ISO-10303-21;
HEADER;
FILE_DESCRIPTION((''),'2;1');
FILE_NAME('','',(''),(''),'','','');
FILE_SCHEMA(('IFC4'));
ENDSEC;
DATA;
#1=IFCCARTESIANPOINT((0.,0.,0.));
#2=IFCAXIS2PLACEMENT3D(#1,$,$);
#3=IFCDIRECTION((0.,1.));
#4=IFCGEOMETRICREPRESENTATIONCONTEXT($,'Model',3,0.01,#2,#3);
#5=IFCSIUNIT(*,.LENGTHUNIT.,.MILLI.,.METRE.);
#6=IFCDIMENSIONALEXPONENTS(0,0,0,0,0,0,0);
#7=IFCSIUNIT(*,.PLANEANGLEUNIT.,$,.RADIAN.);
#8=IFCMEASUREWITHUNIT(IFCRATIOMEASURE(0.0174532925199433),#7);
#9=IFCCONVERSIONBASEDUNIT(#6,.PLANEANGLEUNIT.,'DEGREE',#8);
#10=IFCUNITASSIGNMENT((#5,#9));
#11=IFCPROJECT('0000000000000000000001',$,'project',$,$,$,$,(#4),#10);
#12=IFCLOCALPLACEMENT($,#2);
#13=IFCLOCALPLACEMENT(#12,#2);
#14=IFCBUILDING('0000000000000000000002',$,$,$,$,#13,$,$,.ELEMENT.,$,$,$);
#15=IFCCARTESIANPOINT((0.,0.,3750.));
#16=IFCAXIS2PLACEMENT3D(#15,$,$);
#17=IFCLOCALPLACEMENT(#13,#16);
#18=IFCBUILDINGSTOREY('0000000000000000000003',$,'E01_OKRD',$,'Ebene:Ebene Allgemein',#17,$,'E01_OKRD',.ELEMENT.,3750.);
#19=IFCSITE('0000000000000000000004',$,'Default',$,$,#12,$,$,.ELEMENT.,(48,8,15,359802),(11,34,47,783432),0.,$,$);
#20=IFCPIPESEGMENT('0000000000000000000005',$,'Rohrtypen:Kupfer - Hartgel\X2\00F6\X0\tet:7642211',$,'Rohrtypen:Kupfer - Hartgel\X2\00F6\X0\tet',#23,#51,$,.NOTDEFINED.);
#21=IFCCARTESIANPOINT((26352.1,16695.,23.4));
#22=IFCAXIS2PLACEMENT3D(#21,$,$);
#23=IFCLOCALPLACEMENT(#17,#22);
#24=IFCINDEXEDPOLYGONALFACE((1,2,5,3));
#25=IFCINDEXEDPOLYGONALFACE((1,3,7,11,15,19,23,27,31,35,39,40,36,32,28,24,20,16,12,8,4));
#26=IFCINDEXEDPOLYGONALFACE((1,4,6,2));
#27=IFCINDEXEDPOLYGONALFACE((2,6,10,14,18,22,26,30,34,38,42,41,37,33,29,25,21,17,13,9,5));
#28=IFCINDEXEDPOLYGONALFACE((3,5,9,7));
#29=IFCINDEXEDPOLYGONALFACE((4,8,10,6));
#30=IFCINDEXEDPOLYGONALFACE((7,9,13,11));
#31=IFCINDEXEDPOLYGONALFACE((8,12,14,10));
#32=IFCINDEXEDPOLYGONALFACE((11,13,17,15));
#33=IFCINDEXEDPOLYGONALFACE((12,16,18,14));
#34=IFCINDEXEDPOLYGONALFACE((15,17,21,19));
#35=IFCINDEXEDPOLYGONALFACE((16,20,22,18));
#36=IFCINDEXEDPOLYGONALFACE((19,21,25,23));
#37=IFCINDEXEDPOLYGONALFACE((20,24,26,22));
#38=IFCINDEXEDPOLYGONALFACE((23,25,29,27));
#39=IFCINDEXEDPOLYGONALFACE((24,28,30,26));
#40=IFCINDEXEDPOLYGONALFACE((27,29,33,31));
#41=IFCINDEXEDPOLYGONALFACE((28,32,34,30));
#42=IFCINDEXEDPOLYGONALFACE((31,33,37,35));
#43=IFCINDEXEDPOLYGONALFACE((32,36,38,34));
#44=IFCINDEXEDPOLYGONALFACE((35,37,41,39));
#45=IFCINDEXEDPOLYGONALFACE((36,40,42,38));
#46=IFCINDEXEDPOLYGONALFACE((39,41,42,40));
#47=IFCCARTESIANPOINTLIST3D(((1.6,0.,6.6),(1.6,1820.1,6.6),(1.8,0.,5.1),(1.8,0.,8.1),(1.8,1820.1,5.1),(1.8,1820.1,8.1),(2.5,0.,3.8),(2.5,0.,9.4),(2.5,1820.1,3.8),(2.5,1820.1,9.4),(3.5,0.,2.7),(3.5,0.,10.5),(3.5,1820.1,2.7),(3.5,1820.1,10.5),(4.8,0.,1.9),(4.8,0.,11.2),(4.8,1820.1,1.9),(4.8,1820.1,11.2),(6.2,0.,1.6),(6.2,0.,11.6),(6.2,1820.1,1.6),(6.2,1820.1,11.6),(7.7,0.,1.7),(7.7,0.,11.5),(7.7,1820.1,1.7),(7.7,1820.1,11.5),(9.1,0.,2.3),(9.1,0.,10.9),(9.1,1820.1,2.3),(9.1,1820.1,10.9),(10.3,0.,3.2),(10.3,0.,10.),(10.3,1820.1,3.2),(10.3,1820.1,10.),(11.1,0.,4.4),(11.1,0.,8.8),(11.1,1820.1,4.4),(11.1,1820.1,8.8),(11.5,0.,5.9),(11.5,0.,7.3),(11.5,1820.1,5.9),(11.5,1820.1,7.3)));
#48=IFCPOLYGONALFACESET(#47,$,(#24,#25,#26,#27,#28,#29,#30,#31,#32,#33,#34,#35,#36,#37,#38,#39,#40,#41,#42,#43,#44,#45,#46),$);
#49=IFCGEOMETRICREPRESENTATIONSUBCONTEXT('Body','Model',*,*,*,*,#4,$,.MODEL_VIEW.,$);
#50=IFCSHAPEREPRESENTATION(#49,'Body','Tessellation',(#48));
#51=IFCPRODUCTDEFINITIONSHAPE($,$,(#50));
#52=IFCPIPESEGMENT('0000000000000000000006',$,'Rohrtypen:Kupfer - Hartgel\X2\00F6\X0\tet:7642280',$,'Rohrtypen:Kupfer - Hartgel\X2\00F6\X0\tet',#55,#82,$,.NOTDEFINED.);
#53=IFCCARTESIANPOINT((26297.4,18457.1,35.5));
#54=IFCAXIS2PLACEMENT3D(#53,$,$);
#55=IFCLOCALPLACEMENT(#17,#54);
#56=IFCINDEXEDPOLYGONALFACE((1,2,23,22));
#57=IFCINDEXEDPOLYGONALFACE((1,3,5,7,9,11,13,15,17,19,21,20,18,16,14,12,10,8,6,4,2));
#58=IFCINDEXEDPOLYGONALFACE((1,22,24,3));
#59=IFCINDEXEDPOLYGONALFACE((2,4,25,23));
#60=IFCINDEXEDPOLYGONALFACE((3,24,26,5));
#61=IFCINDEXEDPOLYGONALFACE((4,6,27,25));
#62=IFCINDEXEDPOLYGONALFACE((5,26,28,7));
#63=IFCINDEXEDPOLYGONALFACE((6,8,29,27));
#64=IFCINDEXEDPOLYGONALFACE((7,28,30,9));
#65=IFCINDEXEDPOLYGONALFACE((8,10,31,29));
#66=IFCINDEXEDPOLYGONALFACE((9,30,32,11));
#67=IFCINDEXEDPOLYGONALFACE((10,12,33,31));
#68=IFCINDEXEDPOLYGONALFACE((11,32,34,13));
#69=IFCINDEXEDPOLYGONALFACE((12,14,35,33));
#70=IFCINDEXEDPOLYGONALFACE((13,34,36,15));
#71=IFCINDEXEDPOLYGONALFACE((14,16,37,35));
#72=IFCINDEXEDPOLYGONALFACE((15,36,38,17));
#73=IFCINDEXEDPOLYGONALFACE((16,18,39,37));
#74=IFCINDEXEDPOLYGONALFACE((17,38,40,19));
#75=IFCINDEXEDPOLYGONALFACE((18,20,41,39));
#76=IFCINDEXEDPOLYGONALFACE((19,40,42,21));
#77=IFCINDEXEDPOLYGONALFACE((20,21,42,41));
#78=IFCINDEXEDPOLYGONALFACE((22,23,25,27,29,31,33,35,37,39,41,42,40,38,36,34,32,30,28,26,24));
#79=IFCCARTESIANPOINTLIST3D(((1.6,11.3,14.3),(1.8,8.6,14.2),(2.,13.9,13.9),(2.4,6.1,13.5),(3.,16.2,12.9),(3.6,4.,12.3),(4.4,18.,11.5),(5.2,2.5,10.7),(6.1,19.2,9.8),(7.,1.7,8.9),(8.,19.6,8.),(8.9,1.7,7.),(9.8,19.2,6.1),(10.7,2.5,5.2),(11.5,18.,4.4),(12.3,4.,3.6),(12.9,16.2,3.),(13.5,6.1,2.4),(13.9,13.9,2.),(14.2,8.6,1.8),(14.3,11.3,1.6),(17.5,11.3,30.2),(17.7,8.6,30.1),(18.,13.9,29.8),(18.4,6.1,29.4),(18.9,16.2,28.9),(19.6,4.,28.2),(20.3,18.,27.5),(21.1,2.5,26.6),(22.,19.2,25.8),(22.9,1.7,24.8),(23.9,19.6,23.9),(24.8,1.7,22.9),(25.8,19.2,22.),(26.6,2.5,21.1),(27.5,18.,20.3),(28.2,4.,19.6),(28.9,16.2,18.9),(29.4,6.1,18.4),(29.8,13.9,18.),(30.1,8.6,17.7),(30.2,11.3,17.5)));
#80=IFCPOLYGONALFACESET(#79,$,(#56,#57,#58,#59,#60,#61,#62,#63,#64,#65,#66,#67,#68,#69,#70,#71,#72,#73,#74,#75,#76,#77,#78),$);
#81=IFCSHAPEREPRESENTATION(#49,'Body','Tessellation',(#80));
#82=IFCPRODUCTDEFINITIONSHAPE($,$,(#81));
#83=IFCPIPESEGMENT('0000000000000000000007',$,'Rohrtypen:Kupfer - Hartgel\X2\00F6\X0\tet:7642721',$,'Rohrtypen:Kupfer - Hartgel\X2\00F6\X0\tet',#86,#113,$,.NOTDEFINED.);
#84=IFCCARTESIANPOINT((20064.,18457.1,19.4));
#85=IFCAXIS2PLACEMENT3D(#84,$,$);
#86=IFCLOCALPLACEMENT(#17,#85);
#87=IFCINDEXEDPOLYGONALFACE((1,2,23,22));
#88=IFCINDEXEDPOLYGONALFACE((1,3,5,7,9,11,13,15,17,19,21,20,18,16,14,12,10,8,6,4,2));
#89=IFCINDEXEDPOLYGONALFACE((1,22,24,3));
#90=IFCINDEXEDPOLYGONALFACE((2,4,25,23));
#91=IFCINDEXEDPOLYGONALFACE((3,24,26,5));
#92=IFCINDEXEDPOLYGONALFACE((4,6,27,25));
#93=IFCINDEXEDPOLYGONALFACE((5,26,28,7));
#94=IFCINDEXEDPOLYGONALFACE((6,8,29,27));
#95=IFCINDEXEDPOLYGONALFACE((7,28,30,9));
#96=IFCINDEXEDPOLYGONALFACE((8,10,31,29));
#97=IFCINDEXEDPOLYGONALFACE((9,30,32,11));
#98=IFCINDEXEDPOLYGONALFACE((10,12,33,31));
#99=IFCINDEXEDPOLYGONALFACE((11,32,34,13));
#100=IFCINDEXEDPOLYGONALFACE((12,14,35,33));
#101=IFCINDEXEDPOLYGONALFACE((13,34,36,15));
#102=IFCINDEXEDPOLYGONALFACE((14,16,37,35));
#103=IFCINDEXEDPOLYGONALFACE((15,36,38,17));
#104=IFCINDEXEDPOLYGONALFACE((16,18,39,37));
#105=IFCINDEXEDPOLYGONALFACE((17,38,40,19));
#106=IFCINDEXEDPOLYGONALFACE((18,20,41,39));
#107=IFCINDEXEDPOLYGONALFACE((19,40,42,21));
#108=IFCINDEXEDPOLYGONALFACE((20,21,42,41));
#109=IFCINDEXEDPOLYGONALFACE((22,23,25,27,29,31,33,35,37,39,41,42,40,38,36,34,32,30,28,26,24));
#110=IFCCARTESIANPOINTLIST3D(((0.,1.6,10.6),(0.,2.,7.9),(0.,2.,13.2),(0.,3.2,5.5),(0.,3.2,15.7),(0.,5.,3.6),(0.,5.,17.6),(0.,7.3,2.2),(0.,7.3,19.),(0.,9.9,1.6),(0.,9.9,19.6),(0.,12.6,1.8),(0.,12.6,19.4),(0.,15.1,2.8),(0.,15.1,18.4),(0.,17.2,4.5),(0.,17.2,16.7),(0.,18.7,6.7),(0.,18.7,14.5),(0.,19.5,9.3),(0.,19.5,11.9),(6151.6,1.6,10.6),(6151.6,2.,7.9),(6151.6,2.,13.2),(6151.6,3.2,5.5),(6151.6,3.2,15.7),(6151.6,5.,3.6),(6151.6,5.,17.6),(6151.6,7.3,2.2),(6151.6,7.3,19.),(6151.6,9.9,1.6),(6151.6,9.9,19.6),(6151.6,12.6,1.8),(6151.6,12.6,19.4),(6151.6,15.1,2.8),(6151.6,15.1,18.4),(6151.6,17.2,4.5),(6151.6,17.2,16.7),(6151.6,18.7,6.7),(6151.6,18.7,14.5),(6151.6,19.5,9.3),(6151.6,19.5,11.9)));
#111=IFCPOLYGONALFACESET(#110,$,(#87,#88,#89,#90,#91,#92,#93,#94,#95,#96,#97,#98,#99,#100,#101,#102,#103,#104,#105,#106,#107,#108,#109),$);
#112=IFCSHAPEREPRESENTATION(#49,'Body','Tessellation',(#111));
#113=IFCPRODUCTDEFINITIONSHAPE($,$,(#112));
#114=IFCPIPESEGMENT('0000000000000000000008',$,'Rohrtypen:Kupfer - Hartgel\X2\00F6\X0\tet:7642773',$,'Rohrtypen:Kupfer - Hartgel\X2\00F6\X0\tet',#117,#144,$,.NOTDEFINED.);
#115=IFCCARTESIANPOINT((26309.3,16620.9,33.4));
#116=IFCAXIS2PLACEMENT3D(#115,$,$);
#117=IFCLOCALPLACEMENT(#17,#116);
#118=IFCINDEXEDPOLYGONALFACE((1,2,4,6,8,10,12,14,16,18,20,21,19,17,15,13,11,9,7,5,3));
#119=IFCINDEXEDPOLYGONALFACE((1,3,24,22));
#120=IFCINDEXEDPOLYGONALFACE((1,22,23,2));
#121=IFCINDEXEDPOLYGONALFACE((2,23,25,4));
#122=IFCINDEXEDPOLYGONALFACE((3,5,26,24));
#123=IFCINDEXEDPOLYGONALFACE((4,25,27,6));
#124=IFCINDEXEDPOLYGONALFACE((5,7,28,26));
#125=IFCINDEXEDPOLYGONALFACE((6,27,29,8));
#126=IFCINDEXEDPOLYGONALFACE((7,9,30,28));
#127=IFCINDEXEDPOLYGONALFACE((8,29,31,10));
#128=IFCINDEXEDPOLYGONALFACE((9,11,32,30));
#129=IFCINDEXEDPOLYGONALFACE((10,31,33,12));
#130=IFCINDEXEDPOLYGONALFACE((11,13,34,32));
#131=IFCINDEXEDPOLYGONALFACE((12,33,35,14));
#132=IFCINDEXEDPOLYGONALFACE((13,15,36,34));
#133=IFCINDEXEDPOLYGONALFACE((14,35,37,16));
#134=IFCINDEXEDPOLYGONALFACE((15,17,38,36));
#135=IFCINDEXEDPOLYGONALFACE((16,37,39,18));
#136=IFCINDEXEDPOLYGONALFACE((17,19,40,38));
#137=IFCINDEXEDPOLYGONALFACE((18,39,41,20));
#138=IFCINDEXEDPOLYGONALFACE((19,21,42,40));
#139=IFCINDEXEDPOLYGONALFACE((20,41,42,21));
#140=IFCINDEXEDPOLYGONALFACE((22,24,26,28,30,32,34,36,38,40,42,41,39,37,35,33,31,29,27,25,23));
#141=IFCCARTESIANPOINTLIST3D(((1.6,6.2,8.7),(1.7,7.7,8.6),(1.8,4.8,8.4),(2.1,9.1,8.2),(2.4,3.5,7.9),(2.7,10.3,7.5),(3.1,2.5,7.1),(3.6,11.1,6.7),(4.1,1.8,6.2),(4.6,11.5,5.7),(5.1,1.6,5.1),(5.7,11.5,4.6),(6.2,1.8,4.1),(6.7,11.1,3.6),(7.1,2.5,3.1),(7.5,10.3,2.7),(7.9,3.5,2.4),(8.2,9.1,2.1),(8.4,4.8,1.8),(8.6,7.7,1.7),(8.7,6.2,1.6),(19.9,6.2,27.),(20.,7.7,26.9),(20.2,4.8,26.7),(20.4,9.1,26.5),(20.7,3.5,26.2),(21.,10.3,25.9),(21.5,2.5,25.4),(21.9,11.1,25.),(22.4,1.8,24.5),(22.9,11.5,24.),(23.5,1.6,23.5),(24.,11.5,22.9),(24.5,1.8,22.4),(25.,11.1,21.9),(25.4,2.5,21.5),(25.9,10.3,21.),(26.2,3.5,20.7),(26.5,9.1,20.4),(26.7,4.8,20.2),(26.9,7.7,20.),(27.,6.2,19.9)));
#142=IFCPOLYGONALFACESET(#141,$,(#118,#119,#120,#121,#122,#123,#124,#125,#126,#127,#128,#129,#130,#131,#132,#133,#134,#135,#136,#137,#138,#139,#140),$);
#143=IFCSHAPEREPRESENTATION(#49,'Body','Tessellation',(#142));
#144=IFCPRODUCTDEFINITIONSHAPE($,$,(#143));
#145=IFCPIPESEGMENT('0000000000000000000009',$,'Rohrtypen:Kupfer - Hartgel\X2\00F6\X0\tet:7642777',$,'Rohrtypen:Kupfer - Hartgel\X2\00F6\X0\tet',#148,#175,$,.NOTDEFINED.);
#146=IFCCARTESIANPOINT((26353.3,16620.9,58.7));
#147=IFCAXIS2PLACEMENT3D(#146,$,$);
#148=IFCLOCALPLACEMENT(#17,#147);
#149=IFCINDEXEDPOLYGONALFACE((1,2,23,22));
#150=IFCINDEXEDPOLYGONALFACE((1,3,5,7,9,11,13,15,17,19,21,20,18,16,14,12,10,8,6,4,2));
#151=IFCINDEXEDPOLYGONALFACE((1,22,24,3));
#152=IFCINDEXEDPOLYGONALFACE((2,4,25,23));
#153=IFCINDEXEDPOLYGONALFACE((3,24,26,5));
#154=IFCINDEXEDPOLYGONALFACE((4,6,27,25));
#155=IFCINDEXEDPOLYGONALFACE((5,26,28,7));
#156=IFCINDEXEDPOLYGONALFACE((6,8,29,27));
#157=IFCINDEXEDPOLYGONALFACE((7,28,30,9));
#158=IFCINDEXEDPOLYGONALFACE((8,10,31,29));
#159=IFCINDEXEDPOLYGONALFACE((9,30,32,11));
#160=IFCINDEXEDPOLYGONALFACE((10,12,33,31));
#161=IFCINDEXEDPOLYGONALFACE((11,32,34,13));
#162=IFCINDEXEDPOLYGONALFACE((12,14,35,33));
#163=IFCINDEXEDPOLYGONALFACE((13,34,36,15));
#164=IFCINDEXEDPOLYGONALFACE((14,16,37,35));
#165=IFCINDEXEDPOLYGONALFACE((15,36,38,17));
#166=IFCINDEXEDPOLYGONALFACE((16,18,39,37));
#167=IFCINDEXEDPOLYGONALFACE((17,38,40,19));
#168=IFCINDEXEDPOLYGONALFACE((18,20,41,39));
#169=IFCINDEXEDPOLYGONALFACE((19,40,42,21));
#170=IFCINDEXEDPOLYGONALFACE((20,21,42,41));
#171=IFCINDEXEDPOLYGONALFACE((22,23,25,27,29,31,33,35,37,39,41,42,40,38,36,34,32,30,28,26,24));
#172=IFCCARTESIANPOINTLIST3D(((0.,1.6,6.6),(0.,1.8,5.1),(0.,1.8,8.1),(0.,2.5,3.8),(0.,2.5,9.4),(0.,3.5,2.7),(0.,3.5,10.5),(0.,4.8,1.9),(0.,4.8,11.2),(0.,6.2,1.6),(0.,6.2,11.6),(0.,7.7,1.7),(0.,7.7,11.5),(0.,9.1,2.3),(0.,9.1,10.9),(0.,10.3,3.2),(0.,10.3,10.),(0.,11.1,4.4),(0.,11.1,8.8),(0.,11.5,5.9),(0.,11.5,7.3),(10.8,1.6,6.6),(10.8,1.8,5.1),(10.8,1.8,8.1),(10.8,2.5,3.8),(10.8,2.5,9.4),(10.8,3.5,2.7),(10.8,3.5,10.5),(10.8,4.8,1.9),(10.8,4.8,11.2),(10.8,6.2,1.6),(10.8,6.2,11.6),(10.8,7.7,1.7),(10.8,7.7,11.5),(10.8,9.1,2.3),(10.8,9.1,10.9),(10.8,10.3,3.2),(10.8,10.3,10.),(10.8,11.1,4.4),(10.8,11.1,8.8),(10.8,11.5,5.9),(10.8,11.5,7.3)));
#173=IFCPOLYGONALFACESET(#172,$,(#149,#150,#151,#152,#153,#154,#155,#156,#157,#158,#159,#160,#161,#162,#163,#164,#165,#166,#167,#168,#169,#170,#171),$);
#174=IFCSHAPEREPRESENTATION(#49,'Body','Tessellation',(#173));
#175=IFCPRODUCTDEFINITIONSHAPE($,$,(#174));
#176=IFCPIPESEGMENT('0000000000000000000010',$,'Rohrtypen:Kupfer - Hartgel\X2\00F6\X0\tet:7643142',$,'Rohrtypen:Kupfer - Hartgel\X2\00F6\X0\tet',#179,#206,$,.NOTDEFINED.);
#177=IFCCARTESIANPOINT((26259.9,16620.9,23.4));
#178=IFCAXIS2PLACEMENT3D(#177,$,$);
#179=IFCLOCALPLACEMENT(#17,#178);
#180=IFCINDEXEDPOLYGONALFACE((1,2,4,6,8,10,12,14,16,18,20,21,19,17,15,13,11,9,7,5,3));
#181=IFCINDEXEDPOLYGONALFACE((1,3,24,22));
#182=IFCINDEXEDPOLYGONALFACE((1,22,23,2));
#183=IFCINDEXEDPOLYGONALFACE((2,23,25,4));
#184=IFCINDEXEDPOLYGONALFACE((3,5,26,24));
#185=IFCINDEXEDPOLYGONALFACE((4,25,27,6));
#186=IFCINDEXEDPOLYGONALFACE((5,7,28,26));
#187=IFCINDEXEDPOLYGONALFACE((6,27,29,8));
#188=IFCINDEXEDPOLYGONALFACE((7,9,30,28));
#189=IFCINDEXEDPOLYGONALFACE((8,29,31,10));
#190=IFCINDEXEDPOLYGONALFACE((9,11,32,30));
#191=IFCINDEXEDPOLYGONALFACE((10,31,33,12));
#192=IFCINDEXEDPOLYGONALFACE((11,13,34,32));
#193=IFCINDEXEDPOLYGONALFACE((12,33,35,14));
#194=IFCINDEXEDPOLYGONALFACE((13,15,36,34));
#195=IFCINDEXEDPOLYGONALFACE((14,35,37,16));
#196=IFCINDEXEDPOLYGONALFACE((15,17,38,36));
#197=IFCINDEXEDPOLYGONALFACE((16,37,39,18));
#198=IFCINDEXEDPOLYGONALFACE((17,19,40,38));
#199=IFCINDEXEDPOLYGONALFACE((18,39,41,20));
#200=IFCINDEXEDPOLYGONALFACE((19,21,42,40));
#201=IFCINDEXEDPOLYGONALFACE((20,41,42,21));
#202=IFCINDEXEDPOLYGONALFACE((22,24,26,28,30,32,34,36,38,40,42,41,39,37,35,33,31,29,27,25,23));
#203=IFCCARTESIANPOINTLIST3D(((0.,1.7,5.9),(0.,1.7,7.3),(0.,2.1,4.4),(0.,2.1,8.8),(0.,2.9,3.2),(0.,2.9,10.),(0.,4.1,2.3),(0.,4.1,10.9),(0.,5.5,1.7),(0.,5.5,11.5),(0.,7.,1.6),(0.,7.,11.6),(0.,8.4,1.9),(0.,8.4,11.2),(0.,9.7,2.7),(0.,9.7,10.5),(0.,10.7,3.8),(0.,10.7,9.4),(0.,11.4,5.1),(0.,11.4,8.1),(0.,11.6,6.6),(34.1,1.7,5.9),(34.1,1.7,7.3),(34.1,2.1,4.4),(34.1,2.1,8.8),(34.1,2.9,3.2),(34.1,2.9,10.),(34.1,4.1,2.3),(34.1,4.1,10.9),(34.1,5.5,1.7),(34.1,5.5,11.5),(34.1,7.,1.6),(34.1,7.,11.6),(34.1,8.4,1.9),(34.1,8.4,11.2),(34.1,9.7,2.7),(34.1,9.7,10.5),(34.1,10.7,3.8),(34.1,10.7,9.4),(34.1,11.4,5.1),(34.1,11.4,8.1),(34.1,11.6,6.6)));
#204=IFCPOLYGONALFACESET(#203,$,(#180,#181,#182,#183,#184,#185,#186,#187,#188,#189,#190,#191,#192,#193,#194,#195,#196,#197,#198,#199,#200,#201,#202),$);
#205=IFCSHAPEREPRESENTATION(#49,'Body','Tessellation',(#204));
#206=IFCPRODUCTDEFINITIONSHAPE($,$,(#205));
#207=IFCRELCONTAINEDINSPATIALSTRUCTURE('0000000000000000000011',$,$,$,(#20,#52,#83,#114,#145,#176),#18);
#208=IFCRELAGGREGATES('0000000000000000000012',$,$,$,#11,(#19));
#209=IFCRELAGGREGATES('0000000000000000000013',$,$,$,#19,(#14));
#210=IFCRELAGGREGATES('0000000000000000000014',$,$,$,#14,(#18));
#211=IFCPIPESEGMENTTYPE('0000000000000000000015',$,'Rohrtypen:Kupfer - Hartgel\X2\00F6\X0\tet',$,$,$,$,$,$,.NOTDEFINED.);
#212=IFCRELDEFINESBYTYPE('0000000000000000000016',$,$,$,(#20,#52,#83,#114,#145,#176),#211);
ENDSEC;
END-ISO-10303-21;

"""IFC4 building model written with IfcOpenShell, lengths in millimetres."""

from ifc_helpers import new_model, entity, si_unit, converted_unit, direction, frame, frame_2d, origin, origin_2d_with_axis, place, context, subcontext, project, spatial, circle, extrude, type_object, element, save


model = new_model("IFC4")

# Units and contexts
model_context = context("Model", 3, precision=0.01, world=origin(), true_north=direction((0.0, 1.0)))
body_context = subcontext(model_context, "Body", "Model", "MODEL_VIEW")
ifc_project = project(units=[si_unit("LENGTHUNIT", "METRE", prefix="MILLI"), converted_unit("PLANEANGLEUNIT", "DEGREE", entity("IfcRatioMeasure", 0.0174532925199433), si_unit("PLANEANGLEUNIT", "RADIAN"), dimensions=[0, 0, 0, 0, 0, 0, 0])], contexts=[model_context])

# Site, building, storey
site_placement = place(None, origin())
site = spatial("IfcSite", under=ifc_project, at=site_placement, Name="Default", CompositionType="ELEMENT", RefLatitude=(48, 8, 15, 359802), RefLongitude=(11, 34, 47, 783432), RefElevation=0.0)
building_placement = place(site_placement, origin())
building = spatial("IfcBuilding", under=site, at=building_placement, CompositionType="ELEMENT")
storey_placement = place(building_placement, frame((0.0, 0.0, 3750.0)))
storey = spatial("IfcBuildingStorey", under=building, at=storey_placement, Name="E01_OKRD", ObjectType="Ebene:Ebene Allgemein", LongName="E01_OKRD", CompositionType="ELEMENT", Elevation=3750.0)

# Pipe segments
pipe_segment_type = type_object("IfcPipeSegmentType", Name="Rohrtypen:Kupfer - Hartgelötet", PredefinedType="NOTDEFINED")
pipe_segment_1_placement = place(storey_placement, frame((26352.1, 16695.0, 23.4)))
element("IfcPipeSegment", 1, at=pipe_segment_1_placement, inside=storey, type_object=pipe_segment_type, Name="Rohrtypen:Kupfer - Hartgelötet:7642211", ObjectType="Rohrtypen:Kupfer - Hartgelötet", PredefinedType="NOTDEFINED", context=body_context, shape_type="SweptSolid", body=[
    extrude(circle(Radius=5.0, at=origin_2d_with_axis()), frame((6.6, 0.0, 6.6), z_axis=(0.0, 1.0, 0.0), x_axis=(-1.0, 0.0, 0.0)), (0.0, 0.0, 1.0), 1820.1),
])
pipe_segment_2_placement = place(storey_placement, frame((26297.4, 18457.1, 35.5)))
element("IfcPipeSegment", 2, at=pipe_segment_2_placement, inside=storey, type_object=pipe_segment_type, Name="Rohrtypen:Kupfer - Hartgelötet:7642280", ObjectType="Rohrtypen:Kupfer - Hartgelötet", PredefinedType="NOTDEFINED", context=body_context, shape_type="SweptSolid", body=[
    extrude(circle(Radius=9.0, at=origin_2d_with_axis()), frame((8.0, 10.6, 8.0), z_axis=(0.707107, 0.0, 0.707107), x_axis=(0.0, 1.0, 0.0)), (0.0, 0.0, 1.0), 22.5),
])
pipe_segment_3_placement = place(storey_placement, frame((20064.0, 18457.1, 19.4)))
element("IfcPipeSegment", 3, at=pipe_segment_3_placement, inside=storey, type_object=pipe_segment_type, Name="Rohrtypen:Kupfer - Hartgelötet:7642721", ObjectType="Rohrtypen:Kupfer - Hartgelötet", PredefinedType="NOTDEFINED", context=body_context, shape_type="SweptSolid", body=[
    extrude(circle(Radius=9.0, at=frame_2d((0.0, 0.0), x_axis=(1.0, 0.0))), frame((0.0, 10.6, 10.6), z_axis=(1.0, 0.0, 0.0), x_axis=(0.0, -1.0, 0.0)), (0.0, 0.0, 1.0), 6151.6),
])
pipe_segment_4_placement = place(storey_placement, frame((26309.3, 16620.9, 33.4)))
element("IfcPipeSegment", 4, at=pipe_segment_4_placement, inside=storey, type_object=pipe_segment_type, Name="Rohrtypen:Kupfer - Hartgelötet:7642773", ObjectType="Rohrtypen:Kupfer - Hartgelötet", PredefinedType="NOTDEFINED", context=body_context, shape_type="SweptSolid", body=[
    extrude(circle(Radius=5.0, at=frame_2d((0.0, 0.0), x_axis=(1.0, 0.0))), frame((5.1, 6.6, 5.1), z_axis=(0.707107, 0.0, 0.707107), x_axis=(0.0, -1.0, 0.0)), (0.0, 0.0, 1.0), 25.9),
])
pipe_segment_5_placement = place(storey_placement, frame((26353.3, 16620.9, 58.7)))
element("IfcPipeSegment", 5, at=pipe_segment_5_placement, inside=storey, type_object=pipe_segment_type, Name="Rohrtypen:Kupfer - Hartgelötet:7642777", ObjectType="Rohrtypen:Kupfer - Hartgelötet", PredefinedType="NOTDEFINED", context=body_context, shape_type="SweptSolid", body=[
    extrude(circle(Radius=5.0, at=origin_2d_with_axis()), frame((0.0, 6.6, 6.6), z_axis=(1.0, 0.0, 0.0), x_axis=(0.0, -1.0, 0.0)), (0.0, 0.0, 1.0), 10.8),
])
pipe_segment_6_placement = place(storey_placement, frame((26259.9, 16620.9, 23.4)))
element("IfcPipeSegment", 6, at=pipe_segment_6_placement, inside=storey, type_object=pipe_segment_type, Name="Rohrtypen:Kupfer - Hartgelötet:7643142", ObjectType="Rohrtypen:Kupfer - Hartgelötet", PredefinedType="NOTDEFINED", context=body_context, shape_type="SweptSolid", body=[
    extrude(circle(Radius=5.0, at=frame_2d((0.0, 0.0), x_axis=(1.0, 0.0))), frame((0.0, 6.6, 6.6), z_axis=(1.0, 0.0, 0.0), x_axis=(0.0, 1.0, 0.0)), (0.0, 0.0, 1.0), 34.1),
])

save(model, "model.ifc")
